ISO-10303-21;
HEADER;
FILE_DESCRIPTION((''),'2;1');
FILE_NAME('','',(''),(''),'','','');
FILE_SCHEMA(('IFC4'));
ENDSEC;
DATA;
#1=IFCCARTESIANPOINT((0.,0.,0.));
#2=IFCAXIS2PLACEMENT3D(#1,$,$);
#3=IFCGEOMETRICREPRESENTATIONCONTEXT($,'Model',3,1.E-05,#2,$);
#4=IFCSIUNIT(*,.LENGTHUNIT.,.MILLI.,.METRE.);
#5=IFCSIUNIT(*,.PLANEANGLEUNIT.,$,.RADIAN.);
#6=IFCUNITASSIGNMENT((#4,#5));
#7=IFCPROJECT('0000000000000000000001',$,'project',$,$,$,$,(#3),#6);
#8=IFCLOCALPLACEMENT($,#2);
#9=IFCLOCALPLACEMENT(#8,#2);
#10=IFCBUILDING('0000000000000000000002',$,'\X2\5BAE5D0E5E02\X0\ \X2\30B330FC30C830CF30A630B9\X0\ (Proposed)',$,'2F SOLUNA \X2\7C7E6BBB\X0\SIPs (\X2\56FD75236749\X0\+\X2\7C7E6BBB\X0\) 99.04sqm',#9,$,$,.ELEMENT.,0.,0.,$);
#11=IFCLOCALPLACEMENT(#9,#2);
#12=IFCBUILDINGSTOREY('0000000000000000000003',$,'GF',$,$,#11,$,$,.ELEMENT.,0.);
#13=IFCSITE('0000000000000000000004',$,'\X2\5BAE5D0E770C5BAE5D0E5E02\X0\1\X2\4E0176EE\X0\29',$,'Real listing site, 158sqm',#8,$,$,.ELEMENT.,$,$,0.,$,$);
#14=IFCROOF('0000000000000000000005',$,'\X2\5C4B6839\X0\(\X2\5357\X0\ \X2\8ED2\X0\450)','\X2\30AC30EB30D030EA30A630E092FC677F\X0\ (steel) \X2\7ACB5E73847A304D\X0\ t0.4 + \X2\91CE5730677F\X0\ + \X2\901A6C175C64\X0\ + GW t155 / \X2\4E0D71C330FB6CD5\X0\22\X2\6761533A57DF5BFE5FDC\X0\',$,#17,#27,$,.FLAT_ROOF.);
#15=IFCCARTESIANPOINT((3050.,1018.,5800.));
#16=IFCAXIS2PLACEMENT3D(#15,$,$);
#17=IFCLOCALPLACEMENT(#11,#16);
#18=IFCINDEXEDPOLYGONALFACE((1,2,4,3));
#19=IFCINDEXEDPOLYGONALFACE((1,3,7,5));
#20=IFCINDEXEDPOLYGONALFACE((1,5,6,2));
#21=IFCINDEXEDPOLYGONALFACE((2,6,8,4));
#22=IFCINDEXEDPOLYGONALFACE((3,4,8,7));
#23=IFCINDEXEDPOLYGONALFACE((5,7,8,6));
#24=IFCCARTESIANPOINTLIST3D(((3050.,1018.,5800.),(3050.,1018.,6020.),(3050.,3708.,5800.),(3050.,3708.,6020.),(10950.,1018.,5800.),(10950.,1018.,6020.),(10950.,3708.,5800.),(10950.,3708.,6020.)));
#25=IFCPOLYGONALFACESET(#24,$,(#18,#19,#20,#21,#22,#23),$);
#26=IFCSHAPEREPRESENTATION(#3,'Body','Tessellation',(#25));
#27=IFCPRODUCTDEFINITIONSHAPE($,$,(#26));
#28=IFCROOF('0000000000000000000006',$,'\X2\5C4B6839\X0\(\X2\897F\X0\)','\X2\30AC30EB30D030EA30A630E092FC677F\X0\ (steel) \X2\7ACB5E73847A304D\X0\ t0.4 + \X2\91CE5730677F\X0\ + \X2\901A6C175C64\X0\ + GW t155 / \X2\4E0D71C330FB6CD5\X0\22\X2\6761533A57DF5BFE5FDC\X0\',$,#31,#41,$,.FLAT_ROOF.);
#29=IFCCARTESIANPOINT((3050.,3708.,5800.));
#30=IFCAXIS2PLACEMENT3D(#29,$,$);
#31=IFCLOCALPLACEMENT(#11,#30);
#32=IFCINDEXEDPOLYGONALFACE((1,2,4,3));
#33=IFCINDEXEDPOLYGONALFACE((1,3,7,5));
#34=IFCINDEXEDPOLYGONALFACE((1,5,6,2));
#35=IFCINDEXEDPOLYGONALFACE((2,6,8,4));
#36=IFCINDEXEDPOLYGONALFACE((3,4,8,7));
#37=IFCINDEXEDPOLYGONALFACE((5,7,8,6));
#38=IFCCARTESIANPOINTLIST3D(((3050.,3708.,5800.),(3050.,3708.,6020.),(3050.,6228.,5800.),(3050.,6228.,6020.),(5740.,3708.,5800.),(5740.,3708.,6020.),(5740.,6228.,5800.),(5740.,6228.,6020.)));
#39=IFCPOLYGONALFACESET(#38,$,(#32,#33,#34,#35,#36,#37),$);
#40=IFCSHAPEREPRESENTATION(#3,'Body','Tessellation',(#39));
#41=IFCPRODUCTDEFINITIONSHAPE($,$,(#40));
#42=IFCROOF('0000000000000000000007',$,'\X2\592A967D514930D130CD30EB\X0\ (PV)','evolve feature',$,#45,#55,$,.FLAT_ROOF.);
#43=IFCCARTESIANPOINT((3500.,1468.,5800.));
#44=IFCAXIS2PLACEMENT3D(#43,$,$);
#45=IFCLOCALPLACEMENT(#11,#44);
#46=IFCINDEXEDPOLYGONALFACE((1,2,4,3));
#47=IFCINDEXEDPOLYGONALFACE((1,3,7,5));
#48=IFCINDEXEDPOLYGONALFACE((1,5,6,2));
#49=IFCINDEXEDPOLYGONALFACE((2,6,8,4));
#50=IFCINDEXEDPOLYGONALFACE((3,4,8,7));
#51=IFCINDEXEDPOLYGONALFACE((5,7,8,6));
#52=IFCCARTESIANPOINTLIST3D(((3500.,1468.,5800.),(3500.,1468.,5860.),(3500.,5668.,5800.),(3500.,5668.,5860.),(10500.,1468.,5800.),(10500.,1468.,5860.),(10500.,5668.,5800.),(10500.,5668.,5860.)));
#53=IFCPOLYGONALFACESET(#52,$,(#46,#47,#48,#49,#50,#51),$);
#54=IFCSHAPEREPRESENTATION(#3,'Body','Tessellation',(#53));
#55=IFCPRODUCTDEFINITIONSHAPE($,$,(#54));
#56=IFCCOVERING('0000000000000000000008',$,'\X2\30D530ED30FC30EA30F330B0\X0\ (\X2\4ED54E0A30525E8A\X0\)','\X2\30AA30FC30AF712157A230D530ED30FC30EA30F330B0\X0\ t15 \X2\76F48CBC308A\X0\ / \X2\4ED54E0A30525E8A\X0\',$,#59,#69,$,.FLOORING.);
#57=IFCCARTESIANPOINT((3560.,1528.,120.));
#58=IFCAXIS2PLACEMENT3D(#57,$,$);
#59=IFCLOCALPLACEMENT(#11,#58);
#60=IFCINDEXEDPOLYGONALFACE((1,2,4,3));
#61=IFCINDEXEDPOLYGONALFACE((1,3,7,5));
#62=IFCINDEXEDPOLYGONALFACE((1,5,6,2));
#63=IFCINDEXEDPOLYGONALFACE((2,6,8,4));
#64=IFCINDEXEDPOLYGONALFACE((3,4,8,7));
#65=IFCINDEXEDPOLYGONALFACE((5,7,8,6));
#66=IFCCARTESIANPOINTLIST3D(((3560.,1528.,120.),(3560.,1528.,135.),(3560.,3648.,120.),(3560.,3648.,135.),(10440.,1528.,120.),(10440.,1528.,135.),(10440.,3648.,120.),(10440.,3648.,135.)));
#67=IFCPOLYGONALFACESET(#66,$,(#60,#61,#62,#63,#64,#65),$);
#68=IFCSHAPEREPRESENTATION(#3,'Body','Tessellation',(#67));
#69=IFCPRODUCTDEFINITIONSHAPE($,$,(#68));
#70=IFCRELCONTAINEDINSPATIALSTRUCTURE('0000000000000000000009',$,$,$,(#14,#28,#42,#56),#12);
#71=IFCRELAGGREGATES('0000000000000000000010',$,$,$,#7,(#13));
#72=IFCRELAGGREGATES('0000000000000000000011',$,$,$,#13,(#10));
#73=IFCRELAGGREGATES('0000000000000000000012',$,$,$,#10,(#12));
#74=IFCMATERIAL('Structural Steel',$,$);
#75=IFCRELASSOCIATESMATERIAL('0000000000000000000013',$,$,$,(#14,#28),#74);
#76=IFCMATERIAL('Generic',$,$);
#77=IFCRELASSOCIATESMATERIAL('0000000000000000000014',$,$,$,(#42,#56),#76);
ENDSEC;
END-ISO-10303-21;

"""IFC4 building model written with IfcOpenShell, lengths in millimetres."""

from ifc_helpers import new_model, si_unit, frame, frame_2d, origin, place, context, project, spatial, rectangle, extrude, material, element, save


model = new_model("IFC4")

# Units and contexts
model_context = context("Model", 3, precision=1e-05, world=origin())
ifc_project = project(units=[si_unit("LENGTHUNIT", "METRE", prefix="MILLI"), si_unit("PLANEANGLEUNIT", "RADIAN")], contexts=[model_context])

# Site, building, storey
site_placement = place(None, origin())
site = spatial("IfcSite", under=ifc_project, at=site_placement, Name="宮崎県宮崎市1丁目29", ObjectType="Real listing site, 158sqm", CompositionType="ELEMENT", RefElevation=0.0)
building_placement = place(site_placement, origin())
building = spatial("IfcBuilding", under=site, at=building_placement, Name="宮崎市 コートハウス (Proposed)", ObjectType="2F SOLUNA 籾殻SIPs (国産杉+籾殻) 99.04sqm", CompositionType="ELEMENT", ElevationOfRefHeight=0.0, ElevationOfTerrain=0.0)
storey_placement = place(building_placement, origin())
storey = spatial("IfcBuildingStorey", under=building, at=storey_placement, Name="GF", CompositionType="ELEMENT", Elevation=0.0)

# Shared definitions
ifc_material_1 = material(Name="Generic")

# Roofs
ifc_material_2 = material(Name="Structural Steel")
roof_1_placement = place(storey_placement, frame((3050.0, 1018.0, 5800.0)))
element("IfcRoof", 1, at=roof_1_placement, inside=storey, material=ifc_material_2, Name="屋根(南 軒450)", Description="ガルバリウム鋼板 (steel) 立平葺き t0.4 + 野地板 + 通気層 + GW t155 / 不燃・法22条区域対応", PredefinedType="FLAT_ROOF", context=model_context, shape_type="SweptSolid", body=[
    extrude(rectangle(XDim=7900.0, YDim=2690.0, at=frame_2d((3950.0, 1345.0))), frame((3050.0, 1018.0, 5800.0)), (0.0, 0.0, 1.0), 220.0),
])
roof_2_placement = place(storey_placement, frame((3050.0, 3708.0, 5800.0)))
element("IfcRoof", 2, at=roof_2_placement, inside=storey, material=ifc_material_2, Name="屋根(西)", Description="ガルバリウム鋼板 (steel) 立平葺き t0.4 + 野地板 + 通気層 + GW t155 / 不燃・法22条区域対応", PredefinedType="FLAT_ROOF", context=model_context, shape_type="SweptSolid", body=[
    extrude(rectangle(XDim=2690.0, YDim=2520.0, at=frame_2d((1345.0, 1260.0))), frame((3050.0, 3708.0, 5800.0)), (0.0, 0.0, 1.0), 220.0),
])
roof_3_placement = place(storey_placement, frame((3500.0, 1468.0, 5800.0)))
element("IfcRoof", 3, at=roof_3_placement, inside=storey, material=ifc_material_1, Name="太陽光パネル (PV)", Description="evolve feature", PredefinedType="FLAT_ROOF", context=model_context, shape_type="SweptSolid", body=[
    extrude(rectangle(XDim=7000.0, YDim=4200.0, at=frame_2d((3500.0, 2100.0))), frame((3500.0, 1468.0, 5800.0)), (0.0, 0.0, 1.0), 60.0),
])

# Covering
covering_placement = place(storey_placement, frame((3560.0, 1528.0, 120.0)))
element("IfcCovering", 4, at=covering_placement, inside=storey, material=ifc_material_1, Name="フローリング (仕上げ床)", Description="オーク無垢フローリング t15 直貼り / 仕上げ床", PredefinedType="FLOORING", context=model_context, shape_type="SweptSolid", body=[
    extrude(rectangle(XDim=6880.0, YDim=2120.0, at=frame_2d((3440.0, 1060.0))), frame((3560.0, 1528.0, 120.0)), (0.0, 0.0, 1.0), 15.0),
])

save(model, "model.ifc")
